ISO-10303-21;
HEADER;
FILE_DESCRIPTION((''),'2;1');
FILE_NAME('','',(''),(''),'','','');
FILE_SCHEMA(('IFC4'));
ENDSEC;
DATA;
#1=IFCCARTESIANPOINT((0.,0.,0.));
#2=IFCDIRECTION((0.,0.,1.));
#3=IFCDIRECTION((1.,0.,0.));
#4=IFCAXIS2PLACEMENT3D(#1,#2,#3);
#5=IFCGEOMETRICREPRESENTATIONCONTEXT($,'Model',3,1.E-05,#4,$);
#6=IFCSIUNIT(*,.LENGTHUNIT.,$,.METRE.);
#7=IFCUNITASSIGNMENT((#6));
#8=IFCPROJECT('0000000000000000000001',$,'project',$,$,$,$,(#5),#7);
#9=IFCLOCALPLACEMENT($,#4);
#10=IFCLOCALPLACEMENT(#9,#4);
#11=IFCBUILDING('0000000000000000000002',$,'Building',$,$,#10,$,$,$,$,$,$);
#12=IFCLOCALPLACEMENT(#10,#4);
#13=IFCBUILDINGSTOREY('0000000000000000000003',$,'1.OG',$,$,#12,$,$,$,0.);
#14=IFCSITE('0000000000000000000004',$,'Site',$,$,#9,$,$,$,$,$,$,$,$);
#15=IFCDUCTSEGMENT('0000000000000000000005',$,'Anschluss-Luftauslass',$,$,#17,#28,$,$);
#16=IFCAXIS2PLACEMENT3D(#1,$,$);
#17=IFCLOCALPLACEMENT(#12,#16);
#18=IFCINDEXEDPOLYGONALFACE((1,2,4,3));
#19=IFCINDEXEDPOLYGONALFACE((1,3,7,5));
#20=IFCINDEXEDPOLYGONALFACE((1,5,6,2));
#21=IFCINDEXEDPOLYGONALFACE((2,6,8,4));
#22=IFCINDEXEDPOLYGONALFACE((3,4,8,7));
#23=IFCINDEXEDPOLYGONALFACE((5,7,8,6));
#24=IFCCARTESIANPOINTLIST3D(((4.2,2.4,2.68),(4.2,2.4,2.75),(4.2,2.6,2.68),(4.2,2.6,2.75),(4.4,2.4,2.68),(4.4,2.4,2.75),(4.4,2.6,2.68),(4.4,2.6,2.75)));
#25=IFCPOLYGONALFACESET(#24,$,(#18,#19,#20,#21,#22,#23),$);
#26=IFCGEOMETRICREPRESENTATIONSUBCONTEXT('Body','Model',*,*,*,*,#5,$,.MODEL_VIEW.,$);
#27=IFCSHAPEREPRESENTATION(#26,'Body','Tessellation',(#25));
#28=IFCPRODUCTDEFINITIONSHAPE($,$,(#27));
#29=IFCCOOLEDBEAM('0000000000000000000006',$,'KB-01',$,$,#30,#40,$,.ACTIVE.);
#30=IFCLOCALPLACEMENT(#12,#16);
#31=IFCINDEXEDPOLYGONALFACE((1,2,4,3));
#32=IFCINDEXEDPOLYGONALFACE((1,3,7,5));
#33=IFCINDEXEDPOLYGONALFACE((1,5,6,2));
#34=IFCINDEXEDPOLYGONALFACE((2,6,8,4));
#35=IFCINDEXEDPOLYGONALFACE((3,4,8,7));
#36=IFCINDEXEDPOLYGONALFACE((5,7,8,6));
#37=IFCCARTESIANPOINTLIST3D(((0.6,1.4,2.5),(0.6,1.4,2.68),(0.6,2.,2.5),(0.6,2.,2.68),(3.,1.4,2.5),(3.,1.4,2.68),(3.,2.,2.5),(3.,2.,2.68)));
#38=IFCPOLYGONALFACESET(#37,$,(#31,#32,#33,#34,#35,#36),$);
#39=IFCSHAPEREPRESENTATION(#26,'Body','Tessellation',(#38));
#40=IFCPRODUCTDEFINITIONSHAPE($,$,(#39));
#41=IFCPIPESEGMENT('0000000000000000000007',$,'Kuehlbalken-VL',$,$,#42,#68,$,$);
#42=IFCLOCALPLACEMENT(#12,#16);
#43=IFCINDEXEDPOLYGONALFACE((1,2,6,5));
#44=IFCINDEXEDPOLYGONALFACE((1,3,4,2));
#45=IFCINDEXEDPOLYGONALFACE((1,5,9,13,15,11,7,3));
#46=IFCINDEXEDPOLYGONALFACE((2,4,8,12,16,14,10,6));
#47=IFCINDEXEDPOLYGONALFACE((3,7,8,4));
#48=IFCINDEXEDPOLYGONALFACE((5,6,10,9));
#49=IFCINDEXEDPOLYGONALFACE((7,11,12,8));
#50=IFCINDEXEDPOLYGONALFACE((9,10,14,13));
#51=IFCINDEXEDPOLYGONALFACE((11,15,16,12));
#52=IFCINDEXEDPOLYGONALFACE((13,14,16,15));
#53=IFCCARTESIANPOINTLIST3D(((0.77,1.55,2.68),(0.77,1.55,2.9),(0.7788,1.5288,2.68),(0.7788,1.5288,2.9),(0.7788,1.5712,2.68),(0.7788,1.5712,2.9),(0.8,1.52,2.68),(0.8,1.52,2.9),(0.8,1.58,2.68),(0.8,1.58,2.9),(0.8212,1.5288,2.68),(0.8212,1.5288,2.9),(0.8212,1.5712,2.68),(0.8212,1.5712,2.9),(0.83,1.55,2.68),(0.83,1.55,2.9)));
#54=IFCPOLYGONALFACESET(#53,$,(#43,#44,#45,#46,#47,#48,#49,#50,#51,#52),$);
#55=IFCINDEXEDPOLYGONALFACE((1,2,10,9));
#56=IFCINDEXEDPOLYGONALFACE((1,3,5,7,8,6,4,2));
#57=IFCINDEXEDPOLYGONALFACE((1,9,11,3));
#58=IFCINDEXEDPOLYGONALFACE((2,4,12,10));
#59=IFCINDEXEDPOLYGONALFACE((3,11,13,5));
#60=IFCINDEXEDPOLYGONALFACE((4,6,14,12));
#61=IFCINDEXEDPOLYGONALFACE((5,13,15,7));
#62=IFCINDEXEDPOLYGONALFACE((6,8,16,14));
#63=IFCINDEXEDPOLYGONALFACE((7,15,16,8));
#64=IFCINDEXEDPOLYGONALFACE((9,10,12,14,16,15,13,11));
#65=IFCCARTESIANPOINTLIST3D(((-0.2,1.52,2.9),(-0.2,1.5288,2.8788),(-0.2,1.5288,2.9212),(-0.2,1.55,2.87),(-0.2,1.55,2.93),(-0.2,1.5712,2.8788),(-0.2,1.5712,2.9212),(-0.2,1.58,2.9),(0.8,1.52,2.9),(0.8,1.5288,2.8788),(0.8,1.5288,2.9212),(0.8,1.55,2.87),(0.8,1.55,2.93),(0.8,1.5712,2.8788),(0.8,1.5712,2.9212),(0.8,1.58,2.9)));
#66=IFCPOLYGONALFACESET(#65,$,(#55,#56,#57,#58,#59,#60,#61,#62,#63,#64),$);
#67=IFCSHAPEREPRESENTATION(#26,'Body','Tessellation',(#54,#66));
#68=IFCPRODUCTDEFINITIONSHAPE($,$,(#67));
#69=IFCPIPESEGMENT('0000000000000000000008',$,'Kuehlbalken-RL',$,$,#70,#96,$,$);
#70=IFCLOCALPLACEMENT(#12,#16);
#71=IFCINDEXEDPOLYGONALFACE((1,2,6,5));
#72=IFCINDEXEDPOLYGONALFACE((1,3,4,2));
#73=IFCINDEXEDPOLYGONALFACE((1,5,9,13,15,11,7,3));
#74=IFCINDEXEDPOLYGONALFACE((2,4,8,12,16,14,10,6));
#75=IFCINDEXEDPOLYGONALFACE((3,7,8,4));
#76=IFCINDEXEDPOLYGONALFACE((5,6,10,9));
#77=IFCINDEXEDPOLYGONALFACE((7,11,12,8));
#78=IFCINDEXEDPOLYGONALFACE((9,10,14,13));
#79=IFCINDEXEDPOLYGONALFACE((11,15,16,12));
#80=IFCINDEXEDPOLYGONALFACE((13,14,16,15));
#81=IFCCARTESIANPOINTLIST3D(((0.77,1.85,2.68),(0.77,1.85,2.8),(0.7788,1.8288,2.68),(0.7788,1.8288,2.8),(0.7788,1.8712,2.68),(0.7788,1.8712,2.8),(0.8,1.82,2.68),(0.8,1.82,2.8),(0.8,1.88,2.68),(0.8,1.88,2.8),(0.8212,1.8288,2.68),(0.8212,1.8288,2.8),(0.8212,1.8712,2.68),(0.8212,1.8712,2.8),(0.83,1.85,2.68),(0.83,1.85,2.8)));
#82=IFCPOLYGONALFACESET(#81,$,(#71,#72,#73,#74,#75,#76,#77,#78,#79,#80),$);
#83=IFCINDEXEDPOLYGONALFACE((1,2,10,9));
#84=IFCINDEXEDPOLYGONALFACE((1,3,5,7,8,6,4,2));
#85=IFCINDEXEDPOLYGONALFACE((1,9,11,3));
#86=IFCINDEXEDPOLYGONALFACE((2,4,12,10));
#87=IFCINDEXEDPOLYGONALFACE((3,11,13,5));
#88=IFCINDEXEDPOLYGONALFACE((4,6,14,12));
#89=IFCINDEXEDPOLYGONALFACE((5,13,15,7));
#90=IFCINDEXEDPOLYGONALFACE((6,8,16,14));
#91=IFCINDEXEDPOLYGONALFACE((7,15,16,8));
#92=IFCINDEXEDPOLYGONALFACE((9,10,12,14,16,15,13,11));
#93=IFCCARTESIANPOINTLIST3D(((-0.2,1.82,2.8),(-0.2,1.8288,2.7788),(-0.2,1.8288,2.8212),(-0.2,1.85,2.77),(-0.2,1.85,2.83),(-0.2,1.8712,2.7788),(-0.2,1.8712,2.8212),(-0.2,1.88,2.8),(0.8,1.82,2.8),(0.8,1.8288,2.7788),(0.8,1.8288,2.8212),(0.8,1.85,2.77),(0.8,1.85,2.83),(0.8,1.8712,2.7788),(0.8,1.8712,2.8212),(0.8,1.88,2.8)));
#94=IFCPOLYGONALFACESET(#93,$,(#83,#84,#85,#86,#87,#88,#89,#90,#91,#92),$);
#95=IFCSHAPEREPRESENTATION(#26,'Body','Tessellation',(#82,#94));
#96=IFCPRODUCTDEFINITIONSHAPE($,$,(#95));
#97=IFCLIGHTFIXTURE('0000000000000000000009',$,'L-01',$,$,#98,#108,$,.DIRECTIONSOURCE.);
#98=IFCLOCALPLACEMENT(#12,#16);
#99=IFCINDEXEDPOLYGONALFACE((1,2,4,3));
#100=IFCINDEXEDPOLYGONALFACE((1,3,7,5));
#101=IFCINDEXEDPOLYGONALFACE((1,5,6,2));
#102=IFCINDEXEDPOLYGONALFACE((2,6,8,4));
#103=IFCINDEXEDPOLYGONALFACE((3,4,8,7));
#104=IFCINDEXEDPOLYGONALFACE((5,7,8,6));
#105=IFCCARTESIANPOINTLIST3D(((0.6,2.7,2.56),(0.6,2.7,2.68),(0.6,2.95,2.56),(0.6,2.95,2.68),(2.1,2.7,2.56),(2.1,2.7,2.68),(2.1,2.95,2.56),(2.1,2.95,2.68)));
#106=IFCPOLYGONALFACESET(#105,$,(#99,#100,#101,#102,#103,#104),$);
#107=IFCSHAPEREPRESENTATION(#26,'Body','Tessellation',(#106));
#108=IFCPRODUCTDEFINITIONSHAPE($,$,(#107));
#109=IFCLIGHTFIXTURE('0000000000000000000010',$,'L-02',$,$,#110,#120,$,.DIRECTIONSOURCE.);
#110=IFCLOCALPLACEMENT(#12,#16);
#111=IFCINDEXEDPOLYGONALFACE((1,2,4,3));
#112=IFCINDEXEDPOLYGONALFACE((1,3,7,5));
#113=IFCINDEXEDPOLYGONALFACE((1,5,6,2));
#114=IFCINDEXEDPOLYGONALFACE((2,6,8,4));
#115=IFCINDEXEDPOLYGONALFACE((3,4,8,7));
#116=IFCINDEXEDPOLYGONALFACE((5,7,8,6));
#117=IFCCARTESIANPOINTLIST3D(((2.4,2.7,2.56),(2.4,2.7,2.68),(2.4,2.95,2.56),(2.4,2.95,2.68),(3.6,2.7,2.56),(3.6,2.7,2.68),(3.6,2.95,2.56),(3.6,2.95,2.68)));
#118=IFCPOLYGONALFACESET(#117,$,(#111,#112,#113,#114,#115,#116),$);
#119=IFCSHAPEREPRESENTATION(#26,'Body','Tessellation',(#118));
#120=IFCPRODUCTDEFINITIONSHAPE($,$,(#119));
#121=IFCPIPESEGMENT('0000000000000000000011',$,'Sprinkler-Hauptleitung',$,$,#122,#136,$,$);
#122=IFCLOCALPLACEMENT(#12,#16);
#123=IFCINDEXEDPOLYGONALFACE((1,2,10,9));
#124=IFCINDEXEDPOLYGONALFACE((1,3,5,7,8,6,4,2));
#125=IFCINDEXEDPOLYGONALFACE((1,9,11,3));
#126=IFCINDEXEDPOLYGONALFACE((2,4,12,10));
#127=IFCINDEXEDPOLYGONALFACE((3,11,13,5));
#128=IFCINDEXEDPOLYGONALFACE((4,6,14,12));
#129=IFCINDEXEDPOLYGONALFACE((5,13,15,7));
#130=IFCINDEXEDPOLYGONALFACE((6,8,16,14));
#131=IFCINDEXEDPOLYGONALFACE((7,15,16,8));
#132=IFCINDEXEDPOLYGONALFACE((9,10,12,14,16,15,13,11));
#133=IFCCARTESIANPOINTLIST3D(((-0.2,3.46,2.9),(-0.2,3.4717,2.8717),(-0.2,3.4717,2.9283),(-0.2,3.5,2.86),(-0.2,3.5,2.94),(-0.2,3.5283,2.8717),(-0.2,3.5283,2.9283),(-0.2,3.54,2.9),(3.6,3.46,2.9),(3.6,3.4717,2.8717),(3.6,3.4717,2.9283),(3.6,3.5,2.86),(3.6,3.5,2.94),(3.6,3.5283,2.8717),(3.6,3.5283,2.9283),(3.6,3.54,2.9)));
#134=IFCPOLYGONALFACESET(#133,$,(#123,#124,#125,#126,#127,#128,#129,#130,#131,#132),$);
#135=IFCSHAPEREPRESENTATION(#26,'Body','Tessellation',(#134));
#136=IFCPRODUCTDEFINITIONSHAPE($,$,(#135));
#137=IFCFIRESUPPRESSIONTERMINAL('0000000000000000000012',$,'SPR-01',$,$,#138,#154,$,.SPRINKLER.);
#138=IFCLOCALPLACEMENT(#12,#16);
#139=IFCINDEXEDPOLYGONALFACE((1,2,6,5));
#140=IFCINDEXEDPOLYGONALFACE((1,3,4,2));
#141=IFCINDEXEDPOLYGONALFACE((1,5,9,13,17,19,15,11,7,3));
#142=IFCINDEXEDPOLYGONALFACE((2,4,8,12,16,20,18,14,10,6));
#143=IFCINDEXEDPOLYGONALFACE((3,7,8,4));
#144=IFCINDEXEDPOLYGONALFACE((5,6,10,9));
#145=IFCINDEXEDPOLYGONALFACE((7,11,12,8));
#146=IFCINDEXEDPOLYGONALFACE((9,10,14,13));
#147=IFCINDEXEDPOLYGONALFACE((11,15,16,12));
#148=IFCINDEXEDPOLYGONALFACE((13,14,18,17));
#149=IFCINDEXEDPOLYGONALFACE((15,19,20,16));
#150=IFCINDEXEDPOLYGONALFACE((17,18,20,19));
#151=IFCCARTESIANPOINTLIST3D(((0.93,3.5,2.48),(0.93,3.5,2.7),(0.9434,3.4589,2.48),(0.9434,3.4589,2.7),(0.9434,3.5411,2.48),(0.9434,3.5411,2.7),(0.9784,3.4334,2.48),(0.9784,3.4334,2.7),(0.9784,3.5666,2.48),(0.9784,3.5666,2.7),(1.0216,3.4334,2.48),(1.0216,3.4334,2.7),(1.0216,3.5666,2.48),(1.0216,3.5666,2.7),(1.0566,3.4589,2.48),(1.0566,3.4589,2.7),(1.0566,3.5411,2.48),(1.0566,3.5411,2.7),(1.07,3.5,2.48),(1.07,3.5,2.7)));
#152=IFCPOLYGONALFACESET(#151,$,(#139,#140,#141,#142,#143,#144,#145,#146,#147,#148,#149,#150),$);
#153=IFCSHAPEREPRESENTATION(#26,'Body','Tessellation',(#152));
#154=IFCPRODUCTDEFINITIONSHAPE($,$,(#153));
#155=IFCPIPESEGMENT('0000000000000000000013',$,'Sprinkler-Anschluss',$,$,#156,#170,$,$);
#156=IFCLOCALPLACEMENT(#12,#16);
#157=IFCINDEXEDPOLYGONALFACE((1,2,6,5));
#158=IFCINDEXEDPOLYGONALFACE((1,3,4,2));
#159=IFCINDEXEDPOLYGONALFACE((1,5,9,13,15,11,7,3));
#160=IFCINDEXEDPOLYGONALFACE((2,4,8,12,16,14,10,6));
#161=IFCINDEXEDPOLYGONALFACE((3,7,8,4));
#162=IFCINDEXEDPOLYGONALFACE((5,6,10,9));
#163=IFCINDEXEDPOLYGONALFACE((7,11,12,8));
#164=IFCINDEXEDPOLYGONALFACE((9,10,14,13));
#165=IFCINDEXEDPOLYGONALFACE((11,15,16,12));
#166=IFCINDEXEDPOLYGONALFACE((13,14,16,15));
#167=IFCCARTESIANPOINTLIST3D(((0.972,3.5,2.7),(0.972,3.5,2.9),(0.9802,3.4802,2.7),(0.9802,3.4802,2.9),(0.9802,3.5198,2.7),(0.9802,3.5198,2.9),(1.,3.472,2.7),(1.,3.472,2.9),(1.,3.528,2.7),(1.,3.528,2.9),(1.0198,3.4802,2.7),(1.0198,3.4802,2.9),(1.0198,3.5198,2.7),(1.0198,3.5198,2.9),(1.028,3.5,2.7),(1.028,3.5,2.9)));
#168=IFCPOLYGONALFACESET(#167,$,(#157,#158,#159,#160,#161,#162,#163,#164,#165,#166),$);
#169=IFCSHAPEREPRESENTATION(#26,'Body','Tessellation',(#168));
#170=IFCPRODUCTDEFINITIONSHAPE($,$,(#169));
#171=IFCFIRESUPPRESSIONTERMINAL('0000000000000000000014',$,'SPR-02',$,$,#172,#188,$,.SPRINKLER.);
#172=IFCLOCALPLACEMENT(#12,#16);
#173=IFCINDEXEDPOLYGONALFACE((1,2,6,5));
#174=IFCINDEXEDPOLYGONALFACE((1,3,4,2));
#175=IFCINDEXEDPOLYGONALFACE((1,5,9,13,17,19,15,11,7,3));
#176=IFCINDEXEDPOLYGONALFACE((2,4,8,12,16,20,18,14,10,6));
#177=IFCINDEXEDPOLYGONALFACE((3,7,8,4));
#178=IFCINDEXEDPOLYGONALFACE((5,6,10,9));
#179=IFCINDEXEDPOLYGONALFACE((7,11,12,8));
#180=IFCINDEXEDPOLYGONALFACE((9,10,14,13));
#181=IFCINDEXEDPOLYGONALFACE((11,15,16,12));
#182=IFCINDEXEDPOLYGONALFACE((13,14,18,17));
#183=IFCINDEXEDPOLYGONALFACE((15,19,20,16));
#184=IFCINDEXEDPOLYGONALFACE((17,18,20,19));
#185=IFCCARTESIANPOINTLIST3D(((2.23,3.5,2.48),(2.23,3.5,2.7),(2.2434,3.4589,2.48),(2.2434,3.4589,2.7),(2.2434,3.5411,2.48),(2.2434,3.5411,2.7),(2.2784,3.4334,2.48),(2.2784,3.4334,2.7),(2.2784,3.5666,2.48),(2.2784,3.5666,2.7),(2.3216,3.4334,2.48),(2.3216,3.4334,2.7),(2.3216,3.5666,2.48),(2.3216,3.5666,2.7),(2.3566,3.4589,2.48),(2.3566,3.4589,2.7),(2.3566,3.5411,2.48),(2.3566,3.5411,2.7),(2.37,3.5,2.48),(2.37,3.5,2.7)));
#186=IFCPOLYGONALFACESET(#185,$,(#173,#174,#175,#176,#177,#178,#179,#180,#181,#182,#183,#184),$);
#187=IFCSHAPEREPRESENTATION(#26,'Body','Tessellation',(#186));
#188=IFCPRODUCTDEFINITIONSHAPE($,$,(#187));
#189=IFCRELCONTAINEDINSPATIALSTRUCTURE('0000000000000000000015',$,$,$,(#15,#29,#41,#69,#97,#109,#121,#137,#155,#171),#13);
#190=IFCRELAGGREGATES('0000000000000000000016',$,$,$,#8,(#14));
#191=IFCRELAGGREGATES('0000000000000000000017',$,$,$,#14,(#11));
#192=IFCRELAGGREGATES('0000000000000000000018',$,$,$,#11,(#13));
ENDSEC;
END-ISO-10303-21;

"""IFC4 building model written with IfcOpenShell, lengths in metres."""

from ifc_helpers import new_model, si_unit, frame, origin_with_axes, place, context, subcontext, project, spatial, polyline, outline, extrude, element, save


model = new_model("IFC4")

# Units and contexts
model_context = context("Model", 3, precision=1e-05, world=origin_with_axes())
body_context = subcontext(model_context, "Body", "Model", "MODEL_VIEW")
ifc_project = project(units=[si_unit("LENGTHUNIT", "METRE")], contexts=[model_context])

# Site, building, storey
site_placement = place(None, origin_with_axes())
site = spatial("IfcSite", under=ifc_project, at=site_placement, Name="Site")
building_placement = place(site_placement, origin_with_axes())
building = spatial("IfcBuilding", under=site, at=building_placement, Name="Building")
storey_placement = place(building_placement, origin_with_axes())
storey = spatial("IfcBuildingStorey", under=building, at=storey_placement, Name="1.OG", Elevation=0.0)

# Duct segment
duct_segment_1_placement = place(storey_placement, origin_with_axes())
element("IfcDuctSegment", 1, at=duct_segment_1_placement, inside=storey, Name="Anschluss-Luftauslass", context=body_context, shape_type="SweptSolid", body=[
    extrude(outline(polyline([(-0.1, -0.1, 0.0), (0.1, -0.1, 0.0), (0.1, 0.1, 0.0), (-0.1, 0.1, 0.0), (-0.1, -0.1, 0.0)])), frame((4.3, 2.5, 2.68), z_axis=(0.0, 0.0, 1.0), x_axis=(1.0, 0.0, 0.0)), (0.0, 0.0, 1.0), 0.07),
])

# Cooled beam
cooled_beam_placement = place(storey_placement, origin_with_axes())
element("IfcCooledBeam", 2, at=cooled_beam_placement, inside=storey, Name="KB-01", PredefinedType="ACTIVE", context=body_context, shape_type="SweptSolid", body=[
    extrude(outline(polyline([(0.6, 1.4, 0.0), (3.0, 1.4, 0.0), (3.0, 2.0, 0.0), (0.6, 2.0, 0.0), (0.6, 1.4, 0.0)])), frame((0.0, 0.0, 2.5), z_axis=(0.0, 0.0, 1.0), x_axis=(1.0, 0.0, 0.0)), (0.0, 0.0, 1.0), 0.18),
])

# Pipe segments
pipe_segment_1_placement = place(storey_placement, origin_with_axes())
element("IfcPipeSegment", 3, at=pipe_segment_1_placement, inside=storey, Name="Kuehlbalken-VL", context=body_context, shape_type="SweptSolid", body=[
    extrude(outline(polyline([(0.03, 0.0, 0.0), (0.0212, 0.0212, 0.0), (0.0, 0.03, 0.0), (-0.0212, 0.0212, 0.0), (-0.03, 0.0, 0.0), (-0.0212, -0.0212, 0.0), (0.0, -0.03, 0.0), (0.0212, -0.0212, 0.0), (0.03, 0.0, 0.0)])), frame((0.8, 1.55, 2.68), z_axis=(0.0, 0.0, 1.0), x_axis=(1.0, 0.0, 0.0)), (0.0, 0.0, 1.0), 0.22),
    extrude(outline(polyline([(0.03, 0.0, 0.0), (0.0212, 0.0212, 0.0), (0.0, 0.03, 0.0), (-0.0212, 0.0212, 0.0), (-0.03, 0.0, 0.0), (-0.0212, -0.0212, 0.0), (0.0, -0.03, 0.0), (0.0212, -0.0212, 0.0), (0.03, 0.0, 0.0)])), frame((0.8, 1.55, 2.9), z_axis=(-1.0, 0.0, 0.0), x_axis=(0.0, -1.0, 0.0)), (0.0, 0.0, 1.0), 1.0),
])
pipe_segment_2_placement = place(storey_placement, origin_with_axes())
element("IfcPipeSegment", 4, at=pipe_segment_2_placement, inside=storey, Name="Kuehlbalken-RL", context=body_context, shape_type="SweptSolid", body=[
    extrude(outline(polyline([(0.03, 0.0, 0.0), (0.0212, 0.0212, 0.0), (0.0, 0.03, 0.0), (-0.0212, 0.0212, 0.0), (-0.03, 0.0, 0.0), (-0.0212, -0.0212, 0.0), (0.0, -0.03, 0.0), (0.0212, -0.0212, 0.0), (0.03, 0.0, 0.0)])), frame((0.8, 1.85, 2.68), z_axis=(0.0, 0.0, 1.0), x_axis=(1.0, 0.0, 0.0)), (0.0, 0.0, 1.0), 0.12),
    extrude(outline(polyline([(0.03, 0.0, 0.0), (0.0212, 0.0212, 0.0), (0.0, 0.03, 0.0), (-0.0212, 0.0212, 0.0), (-0.03, 0.0, 0.0), (-0.0212, -0.0212, 0.0), (0.0, -0.03, 0.0), (0.0212, -0.0212, 0.0), (0.03, 0.0, 0.0)])), frame((0.8, 1.85, 2.8), z_axis=(-1.0, 0.0, 0.0), x_axis=(0.0, -1.0, 0.0)), (0.0, 0.0, 1.0), 1.0),
])

# Light fixtures
light_fixture_1_placement = place(storey_placement, origin_with_axes())
element("IfcLightFixture", 5, at=light_fixture_1_placement, inside=storey, Name="L-01", PredefinedType="DIRECTIONSOURCE", context=body_context, shape_type="SweptSolid", body=[
    extrude(outline(polyline([(0.6, 2.7, 0.0), (2.1, 2.7, 0.0), (2.1, 2.95, 0.0), (0.6, 2.95, 0.0), (0.6, 2.7, 0.0)])), frame((0.0, 0.0, 2.56), z_axis=(0.0, 0.0, 1.0), x_axis=(1.0, 0.0, 0.0)), (0.0, 0.0, 1.0), 0.12),
])
light_fixture_2_placement = place(storey_placement, origin_with_axes())
element("IfcLightFixture", 6, at=light_fixture_2_placement, inside=storey, Name="L-02", PredefinedType="DIRECTIONSOURCE", context=body_context, shape_type="SweptSolid", body=[
    extrude(outline(polyline([(2.4, 2.7, 0.0), (3.6, 2.7, 0.0), (3.6, 2.95, 0.0), (2.4, 2.95, 0.0), (2.4, 2.7, 0.0)])), frame((0.0, 0.0, 2.56), z_axis=(0.0, 0.0, 1.0), x_axis=(1.0, 0.0, 0.0)), (0.0, 0.0, 1.0), 0.12),
])

# Pipe segment
pipe_segment_3_placement = place(storey_placement, origin_with_axes())
element("IfcPipeSegment", 7, at=pipe_segment_3_placement, inside=storey, Name="Sprinkler-Hauptleitung", context=body_context, shape_type="SweptSolid", body=[
    extrude(outline(polyline([(0.04, 0.0, 0.0), (0.0283, 0.0283, 0.0), (0.0, 0.04, 0.0), (-0.0283, 0.0283, 0.0), (-0.04, 0.0, 0.0), (-0.0283, -0.0283, 0.0), (0.0, -0.04, 0.0), (0.0283, -0.0283, 0.0), (0.04, 0.0, 0.0)])), frame((-0.2, 3.5, 2.9), z_axis=(1.0, 0.0, 0.0), x_axis=(0.0, 1.0, 0.0)), (0.0, 0.0, 1.0), 3.8),
])

# Fire suppression terminal
fire_suppression_terminal_1_placement = place(storey_placement, origin_with_axes())
element("IfcFireSuppressionTerminal", 8, at=fire_suppression_terminal_1_placement, inside=storey, Name="SPR-01", PredefinedType="SPRINKLER", context=body_context, shape_type="SweptSolid", body=[
    extrude(outline(polyline([(0.07, 0.0, 0.0), (0.0566, 0.0411, 0.0), (0.0216, 0.0666, 0.0), (-0.0216, 0.0666, 0.0), (-0.0566, 0.0411, 0.0), (-0.07, 0.0, 0.0), (-0.0566, -0.0411, 0.0), (-0.0216, -0.0666, 0.0), (0.0216, -0.0666, 0.0), (0.0566, -0.0411, 0.0), (0.07, 0.0, 0.0)])), frame((1.0, 3.5, 2.48), z_axis=(0.0, 0.0, 1.0), x_axis=(1.0, 0.0, 0.0)), (0.0, 0.0, 1.0), 0.22),
])

# Pipe segment
pipe_segment_4_placement = place(storey_placement, origin_with_axes())
element("IfcPipeSegment", 9, at=pipe_segment_4_placement, inside=storey, Name="Sprinkler-Anschluss", context=body_context, shape_type="SweptSolid", body=[
    extrude(outline(polyline([(0.028, 0.0, 0.0), (0.0198, 0.0198, 0.0), (0.0, 0.028, 0.0), (-0.0198, 0.0198, 0.0), (-0.028, 0.0, 0.0), (-0.0198, -0.0198, 0.0), (0.0, -0.028, 0.0), (0.0198, -0.0198, 0.0), (0.028, 0.0, 0.0)])), frame((1.0, 3.5, 2.7), z_axis=(0.0, 0.0, 1.0), x_axis=(1.0, 0.0, 0.0)), (0.0, 0.0, 1.0), 0.2),
])

# Fire suppression terminal
fire_suppression_terminal_2_placement = place(storey_placement, origin_with_axes())
element("IfcFireSuppressionTerminal", 10, at=fire_suppression_terminal_2_placement, inside=storey, Name="SPR-02", PredefinedType="SPRINKLER", context=body_context, shape_type="SweptSolid", body=[
    extrude(outline(polyline([(0.07, 0.0, 0.0), (0.0566, 0.0411, 0.0), (0.0216, 0.0666, 0.0), (-0.0216, 0.0666, 0.0), (-0.0566, 0.0411, 0.0), (-0.07, 0.0, 0.0), (-0.0566, -0.0411, 0.0), (-0.0216, -0.0666, 0.0), (0.0216, -0.0666, 0.0), (0.0566, -0.0411, 0.0), (0.07, 0.0, 0.0)])), frame((2.3, 3.5, 2.48), z_axis=(0.0, 0.0, 1.0), x_axis=(1.0, 0.0, 0.0)), (0.0, 0.0, 1.0), 0.22),
])

save(model, "model.ifc")
